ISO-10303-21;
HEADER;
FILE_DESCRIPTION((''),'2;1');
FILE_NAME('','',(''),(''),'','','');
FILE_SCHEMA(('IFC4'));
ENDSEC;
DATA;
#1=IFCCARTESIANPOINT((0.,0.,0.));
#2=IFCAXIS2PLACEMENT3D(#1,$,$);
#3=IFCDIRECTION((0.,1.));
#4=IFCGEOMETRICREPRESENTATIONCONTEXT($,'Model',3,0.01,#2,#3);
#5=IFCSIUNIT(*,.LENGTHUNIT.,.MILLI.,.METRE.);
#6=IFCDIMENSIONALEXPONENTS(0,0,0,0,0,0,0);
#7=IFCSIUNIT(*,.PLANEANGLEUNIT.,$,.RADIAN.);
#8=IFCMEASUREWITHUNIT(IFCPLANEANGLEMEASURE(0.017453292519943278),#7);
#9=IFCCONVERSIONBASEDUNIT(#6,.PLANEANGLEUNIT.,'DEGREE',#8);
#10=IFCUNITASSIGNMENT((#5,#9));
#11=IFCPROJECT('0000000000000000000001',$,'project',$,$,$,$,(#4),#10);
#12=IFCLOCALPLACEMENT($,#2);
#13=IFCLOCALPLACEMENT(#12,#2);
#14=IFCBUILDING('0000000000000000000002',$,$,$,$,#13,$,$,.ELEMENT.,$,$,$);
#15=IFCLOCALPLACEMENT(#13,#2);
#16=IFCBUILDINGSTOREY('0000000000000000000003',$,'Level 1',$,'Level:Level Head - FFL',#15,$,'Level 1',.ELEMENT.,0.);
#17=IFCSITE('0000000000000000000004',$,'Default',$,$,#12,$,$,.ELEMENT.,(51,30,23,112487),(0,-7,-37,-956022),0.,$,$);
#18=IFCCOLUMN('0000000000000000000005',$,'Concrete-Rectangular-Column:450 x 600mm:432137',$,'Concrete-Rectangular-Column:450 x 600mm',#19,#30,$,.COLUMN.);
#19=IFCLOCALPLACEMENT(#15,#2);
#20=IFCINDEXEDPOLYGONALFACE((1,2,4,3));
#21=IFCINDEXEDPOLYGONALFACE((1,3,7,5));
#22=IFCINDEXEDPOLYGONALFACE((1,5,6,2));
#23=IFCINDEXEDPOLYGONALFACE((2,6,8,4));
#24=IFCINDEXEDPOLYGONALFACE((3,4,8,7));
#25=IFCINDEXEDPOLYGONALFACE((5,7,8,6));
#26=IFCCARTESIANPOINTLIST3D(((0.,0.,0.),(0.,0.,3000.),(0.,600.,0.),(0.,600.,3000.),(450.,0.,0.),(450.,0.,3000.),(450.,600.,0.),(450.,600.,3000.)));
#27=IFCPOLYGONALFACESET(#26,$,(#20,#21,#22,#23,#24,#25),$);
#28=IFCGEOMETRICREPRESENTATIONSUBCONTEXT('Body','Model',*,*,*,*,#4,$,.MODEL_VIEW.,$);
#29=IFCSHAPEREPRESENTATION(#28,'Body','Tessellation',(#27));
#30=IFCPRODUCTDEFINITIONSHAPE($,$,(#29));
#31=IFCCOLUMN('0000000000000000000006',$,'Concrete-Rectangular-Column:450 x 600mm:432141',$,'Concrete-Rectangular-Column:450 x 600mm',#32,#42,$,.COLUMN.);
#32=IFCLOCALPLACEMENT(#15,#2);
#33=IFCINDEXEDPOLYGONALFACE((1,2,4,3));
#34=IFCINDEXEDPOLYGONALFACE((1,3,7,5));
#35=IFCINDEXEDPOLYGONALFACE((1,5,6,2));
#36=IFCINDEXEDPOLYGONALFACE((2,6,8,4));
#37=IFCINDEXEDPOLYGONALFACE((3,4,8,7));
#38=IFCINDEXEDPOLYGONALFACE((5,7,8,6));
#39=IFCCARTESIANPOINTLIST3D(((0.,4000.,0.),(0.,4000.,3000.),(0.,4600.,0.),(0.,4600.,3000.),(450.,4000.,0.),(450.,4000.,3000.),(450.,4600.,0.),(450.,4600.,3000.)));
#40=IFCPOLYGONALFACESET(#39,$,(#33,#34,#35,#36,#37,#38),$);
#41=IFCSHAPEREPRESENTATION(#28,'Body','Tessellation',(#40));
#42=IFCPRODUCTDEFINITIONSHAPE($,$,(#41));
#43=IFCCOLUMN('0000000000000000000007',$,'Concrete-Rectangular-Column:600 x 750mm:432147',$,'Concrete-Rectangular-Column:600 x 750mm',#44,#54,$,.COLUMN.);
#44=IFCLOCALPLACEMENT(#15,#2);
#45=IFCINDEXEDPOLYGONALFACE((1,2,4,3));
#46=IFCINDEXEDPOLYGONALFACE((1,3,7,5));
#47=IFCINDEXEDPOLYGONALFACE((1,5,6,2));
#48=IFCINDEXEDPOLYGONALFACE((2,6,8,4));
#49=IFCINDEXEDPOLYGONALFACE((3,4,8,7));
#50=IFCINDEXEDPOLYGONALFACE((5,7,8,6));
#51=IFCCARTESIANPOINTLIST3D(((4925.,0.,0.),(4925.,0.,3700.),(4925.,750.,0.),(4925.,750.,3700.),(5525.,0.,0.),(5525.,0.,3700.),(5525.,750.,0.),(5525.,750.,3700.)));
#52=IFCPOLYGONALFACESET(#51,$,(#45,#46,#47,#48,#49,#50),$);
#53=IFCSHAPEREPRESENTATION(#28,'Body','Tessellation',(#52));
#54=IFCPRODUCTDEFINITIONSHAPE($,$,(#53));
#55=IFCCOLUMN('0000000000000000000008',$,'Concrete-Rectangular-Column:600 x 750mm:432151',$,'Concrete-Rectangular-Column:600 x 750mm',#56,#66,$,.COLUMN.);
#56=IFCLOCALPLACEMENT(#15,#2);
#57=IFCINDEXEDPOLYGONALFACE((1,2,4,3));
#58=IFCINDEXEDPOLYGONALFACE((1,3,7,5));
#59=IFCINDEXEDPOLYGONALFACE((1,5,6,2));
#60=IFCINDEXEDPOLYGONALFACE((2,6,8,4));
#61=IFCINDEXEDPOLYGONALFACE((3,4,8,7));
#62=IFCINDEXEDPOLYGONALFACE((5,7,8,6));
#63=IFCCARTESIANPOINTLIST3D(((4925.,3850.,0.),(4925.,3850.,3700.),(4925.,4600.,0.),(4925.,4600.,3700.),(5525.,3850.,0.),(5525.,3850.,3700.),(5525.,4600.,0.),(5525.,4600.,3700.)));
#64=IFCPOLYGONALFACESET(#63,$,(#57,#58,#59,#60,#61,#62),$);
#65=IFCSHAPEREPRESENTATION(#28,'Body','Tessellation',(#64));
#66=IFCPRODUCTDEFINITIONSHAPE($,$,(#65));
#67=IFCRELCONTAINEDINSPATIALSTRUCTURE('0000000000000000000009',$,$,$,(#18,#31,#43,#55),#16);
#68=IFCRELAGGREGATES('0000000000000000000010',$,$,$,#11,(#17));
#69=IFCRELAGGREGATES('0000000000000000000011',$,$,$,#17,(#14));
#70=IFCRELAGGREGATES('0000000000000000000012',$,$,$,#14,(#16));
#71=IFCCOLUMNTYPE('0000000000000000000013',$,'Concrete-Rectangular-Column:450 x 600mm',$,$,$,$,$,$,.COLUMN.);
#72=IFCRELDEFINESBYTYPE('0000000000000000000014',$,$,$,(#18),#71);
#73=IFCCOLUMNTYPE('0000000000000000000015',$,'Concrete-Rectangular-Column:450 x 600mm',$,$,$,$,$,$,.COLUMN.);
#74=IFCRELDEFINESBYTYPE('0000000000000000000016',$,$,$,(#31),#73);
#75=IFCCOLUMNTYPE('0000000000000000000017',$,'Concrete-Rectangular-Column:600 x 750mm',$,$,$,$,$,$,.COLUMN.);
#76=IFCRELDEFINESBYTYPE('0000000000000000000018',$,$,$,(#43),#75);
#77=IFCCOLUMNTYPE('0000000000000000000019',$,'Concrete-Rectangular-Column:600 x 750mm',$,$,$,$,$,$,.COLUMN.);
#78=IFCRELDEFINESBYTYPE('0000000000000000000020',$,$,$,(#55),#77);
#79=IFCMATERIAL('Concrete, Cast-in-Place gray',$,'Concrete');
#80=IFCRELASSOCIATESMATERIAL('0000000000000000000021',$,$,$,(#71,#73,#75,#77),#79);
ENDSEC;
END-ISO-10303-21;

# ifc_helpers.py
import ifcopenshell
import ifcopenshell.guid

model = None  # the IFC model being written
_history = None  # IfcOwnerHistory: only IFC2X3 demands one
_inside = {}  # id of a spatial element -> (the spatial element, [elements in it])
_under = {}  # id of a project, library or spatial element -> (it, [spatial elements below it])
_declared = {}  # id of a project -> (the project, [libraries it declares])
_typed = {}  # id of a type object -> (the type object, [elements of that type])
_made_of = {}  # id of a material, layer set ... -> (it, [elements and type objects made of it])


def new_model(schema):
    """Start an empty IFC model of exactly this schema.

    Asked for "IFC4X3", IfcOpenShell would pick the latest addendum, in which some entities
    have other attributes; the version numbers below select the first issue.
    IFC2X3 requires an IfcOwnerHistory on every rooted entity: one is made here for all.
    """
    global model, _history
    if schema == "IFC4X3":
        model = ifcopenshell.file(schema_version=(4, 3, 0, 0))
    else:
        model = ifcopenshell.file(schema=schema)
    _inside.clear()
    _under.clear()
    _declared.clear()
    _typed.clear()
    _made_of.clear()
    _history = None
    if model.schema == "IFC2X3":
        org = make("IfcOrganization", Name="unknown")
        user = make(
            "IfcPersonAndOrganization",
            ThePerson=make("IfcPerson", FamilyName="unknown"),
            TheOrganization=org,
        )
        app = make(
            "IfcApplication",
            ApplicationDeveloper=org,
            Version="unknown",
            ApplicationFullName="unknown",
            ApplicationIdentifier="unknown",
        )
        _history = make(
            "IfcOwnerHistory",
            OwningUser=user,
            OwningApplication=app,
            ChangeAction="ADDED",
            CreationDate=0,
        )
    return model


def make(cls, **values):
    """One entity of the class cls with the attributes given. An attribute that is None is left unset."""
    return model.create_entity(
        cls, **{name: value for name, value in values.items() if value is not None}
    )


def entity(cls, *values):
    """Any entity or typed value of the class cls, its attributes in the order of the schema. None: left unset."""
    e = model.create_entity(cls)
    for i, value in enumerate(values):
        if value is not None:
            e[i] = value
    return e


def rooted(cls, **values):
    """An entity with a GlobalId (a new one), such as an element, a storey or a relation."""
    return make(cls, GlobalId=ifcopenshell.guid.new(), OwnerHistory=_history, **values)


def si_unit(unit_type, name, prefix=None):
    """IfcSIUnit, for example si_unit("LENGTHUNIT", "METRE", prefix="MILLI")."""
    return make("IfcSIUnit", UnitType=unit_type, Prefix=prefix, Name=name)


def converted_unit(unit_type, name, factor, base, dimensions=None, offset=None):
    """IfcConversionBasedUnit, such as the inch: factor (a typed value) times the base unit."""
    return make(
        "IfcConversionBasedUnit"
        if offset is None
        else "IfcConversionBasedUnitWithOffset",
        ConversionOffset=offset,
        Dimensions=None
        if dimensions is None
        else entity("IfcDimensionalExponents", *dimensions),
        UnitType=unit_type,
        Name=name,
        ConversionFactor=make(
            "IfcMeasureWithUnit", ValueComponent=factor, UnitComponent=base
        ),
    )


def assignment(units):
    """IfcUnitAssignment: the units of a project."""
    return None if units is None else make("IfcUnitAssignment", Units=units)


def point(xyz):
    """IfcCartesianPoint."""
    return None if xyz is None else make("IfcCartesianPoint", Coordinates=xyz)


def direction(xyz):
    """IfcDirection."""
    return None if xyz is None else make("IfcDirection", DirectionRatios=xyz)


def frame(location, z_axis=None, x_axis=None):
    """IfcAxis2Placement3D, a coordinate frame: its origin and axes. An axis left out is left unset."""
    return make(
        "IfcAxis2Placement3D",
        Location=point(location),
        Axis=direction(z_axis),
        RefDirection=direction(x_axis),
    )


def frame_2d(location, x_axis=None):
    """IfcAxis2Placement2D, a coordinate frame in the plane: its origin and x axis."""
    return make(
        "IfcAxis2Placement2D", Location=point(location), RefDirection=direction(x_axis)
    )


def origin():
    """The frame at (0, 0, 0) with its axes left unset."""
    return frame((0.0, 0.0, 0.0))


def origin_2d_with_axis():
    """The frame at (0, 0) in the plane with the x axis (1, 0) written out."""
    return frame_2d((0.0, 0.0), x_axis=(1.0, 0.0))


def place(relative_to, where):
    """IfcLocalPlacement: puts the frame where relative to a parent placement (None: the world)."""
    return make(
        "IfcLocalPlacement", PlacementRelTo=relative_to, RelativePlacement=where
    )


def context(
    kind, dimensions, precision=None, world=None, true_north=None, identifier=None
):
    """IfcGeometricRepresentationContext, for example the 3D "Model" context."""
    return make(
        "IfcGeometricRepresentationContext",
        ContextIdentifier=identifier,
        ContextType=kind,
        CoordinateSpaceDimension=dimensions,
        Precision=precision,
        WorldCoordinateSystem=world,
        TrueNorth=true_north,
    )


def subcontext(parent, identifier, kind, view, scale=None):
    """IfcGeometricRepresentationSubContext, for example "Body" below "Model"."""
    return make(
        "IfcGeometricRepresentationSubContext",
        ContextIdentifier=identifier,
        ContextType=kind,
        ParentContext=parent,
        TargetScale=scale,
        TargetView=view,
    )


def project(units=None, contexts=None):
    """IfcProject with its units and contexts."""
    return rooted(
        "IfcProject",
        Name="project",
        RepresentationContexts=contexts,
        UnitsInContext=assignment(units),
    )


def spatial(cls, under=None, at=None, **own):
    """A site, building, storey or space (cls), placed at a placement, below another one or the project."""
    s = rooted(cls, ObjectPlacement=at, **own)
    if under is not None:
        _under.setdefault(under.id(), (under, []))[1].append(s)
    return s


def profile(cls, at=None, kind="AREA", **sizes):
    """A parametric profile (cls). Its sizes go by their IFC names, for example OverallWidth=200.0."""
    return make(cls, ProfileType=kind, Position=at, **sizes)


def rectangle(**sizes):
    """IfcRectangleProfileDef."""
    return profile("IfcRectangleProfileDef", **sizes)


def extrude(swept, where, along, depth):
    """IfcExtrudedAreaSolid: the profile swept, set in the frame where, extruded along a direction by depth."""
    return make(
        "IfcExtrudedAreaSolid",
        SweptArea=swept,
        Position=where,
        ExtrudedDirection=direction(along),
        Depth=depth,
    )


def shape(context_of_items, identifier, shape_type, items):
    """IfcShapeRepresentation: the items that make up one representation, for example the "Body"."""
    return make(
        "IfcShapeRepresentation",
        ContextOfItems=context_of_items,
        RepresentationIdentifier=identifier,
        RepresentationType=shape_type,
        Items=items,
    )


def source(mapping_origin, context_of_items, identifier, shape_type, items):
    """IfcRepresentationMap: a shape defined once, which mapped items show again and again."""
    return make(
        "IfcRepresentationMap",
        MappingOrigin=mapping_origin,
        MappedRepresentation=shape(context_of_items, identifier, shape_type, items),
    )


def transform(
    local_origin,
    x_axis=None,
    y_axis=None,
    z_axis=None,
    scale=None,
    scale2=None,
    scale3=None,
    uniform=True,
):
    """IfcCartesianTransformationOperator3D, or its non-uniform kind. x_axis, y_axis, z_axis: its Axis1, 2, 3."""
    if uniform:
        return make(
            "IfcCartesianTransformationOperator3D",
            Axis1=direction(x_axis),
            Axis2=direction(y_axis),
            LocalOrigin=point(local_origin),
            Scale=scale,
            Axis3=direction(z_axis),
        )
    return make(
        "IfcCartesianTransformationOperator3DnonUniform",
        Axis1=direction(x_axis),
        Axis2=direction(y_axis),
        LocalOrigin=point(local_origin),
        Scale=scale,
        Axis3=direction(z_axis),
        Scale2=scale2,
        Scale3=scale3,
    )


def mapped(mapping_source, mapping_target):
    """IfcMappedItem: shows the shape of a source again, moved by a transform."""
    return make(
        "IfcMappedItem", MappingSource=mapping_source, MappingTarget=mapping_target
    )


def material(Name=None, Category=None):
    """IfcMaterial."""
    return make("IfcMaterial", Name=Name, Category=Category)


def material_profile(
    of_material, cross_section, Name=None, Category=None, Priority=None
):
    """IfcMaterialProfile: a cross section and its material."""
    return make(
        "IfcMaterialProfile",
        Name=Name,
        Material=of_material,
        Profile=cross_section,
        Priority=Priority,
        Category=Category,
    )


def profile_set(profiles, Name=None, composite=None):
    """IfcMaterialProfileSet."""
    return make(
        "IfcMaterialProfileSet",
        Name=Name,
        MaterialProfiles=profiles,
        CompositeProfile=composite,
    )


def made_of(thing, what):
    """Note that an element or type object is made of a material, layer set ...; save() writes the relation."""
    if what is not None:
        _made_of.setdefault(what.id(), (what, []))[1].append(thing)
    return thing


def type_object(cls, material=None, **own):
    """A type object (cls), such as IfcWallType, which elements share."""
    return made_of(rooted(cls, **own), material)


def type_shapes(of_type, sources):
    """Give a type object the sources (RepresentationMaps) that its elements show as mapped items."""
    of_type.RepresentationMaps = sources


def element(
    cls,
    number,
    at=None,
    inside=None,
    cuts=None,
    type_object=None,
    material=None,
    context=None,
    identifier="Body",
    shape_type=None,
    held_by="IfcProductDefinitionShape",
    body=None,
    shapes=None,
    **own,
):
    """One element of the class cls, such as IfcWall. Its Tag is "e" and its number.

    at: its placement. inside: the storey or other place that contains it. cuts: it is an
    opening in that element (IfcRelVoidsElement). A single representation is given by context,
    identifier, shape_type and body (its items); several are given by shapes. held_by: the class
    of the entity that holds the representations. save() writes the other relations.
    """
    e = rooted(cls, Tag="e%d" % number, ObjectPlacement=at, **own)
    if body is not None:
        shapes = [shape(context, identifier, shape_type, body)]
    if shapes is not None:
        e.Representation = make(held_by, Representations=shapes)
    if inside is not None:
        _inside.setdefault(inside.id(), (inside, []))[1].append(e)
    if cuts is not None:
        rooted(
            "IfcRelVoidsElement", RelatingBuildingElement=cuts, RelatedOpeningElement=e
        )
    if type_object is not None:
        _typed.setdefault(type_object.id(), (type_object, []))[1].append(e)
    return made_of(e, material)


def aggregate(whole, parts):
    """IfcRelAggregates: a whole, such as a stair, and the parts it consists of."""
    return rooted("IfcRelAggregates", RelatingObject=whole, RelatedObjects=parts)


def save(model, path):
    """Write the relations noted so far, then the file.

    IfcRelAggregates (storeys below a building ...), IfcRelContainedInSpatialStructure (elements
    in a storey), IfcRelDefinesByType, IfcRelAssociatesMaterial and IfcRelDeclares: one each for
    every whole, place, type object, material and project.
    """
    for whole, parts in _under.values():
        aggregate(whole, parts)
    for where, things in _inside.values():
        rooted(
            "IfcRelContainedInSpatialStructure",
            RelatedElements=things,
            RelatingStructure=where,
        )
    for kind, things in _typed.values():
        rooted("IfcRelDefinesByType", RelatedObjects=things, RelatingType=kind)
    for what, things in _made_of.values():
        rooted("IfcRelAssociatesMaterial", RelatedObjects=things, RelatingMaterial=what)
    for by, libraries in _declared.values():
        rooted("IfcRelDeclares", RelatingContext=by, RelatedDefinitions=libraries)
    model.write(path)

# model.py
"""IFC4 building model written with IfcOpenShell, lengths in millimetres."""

from ifc_helpers import new_model, entity, si_unit, converted_unit, direction, frame, frame_2d, origin, origin_2d_with_axis, place, context, subcontext, project, spatial, rectangle, extrude, source, transform, mapped, material, material_profile, profile_set, type_object, type_shapes, element, save


model = new_model("IFC4")

# Units and contexts
model_context = context("Model", 3, precision=0.01, world=origin(), true_north=direction((0.0, 1.0)))
body_context = subcontext(model_context, "Body", "Model", "MODEL_VIEW")
ifc_project = project(units=[si_unit("LENGTHUNIT", "METRE", prefix="MILLI"), converted_unit("PLANEANGLEUNIT", "DEGREE", entity("IfcPlaneAngleMeasure", 0.017453292519943278), si_unit("PLANEANGLEUNIT", "RADIAN"), dimensions=[0, 0, 0, 0, 0, 0, 0])], contexts=[model_context])

# Site, building, storey
site_placement = place(None, origin())
site = spatial("IfcSite", under=ifc_project, at=site_placement, Name="Default", CompositionType="ELEMENT", RefLatitude=(51, 30, 23, 112487), RefLongitude=(0, -7, -37, -956022), RefElevation=0.0)
building_placement = place(site_placement, origin())
building = spatial("IfcBuilding", under=site, at=building_placement, CompositionType="ELEMENT")
storey_placement = place(building_placement, origin())
storey = spatial("IfcBuildingStorey", under=building, at=storey_placement, Name="Level 1", ObjectType="Level:Level Head - FFL", LongName="Level 1", CompositionType="ELEMENT", Elevation=0.0)

# Columns
ifc_material = material(Name="Concrete, Cast-in-Place gray", Category="Concrete")
ifc_material_profile_1 = material_profile(ifc_material, rectangle(XDim=450.0, YDim=600.0, at=frame_2d((0.0, 0.0), x_axis=(1.0, 0.0))), Name="450 x 600mm")
ifc_profile_set_1 = profile_set([ifc_material_profile_1], Name="450 x 600mm")
column_type_1 = type_object("IfcColumnType", Name="Concrete-Rectangular-Column:450 x 600mm", PredefinedType="COLUMN", material=ifc_profile_set_1)
shared_shape_1 = source(origin(), body_context, "Body", "SweptSolid", [
    extrude(rectangle(XDim=450.0, YDim=600.0, at=frame_2d((0.0, 0.0), x_axis=(1.0, 0.0))), frame((225.0, 300.0, 0.0), z_axis=(0.0, 0.0, 1.0), x_axis=(-1.0, 0.0, 0.0)), (0.0, 0.0, 1.0), 3000.0),
])
type_shapes(column_type_1, [shared_shape_1])
column_1_placement = place(storey_placement, origin())
element("IfcColumn", 1, at=column_1_placement, inside=storey, type_object=column_type_1, Name="Concrete-Rectangular-Column:450 x 600mm:432137", ObjectType="Concrete-Rectangular-Column:450 x 600mm", PredefinedType="COLUMN", context=body_context, shape_type="MappedRepresentation", body=[
    mapped(shared_shape_1, transform((0.0, 0.0, 0.0), scale=1.0)),
])
column_type_2 = type_object("IfcColumnType", Name="Concrete-Rectangular-Column:450 x 600mm", PredefinedType="COLUMN", material=ifc_profile_set_1)
shared_shape_2 = source(origin(), body_context, "Body", "SweptSolid", [
    extrude(rectangle(XDim=450.0, YDim=600.0, at=origin_2d_with_axis()), frame((225.0, 4300.0, 0.0), z_axis=(0.0, 0.0, 1.0), x_axis=(-1.0, 0.0, 0.0)), (0.0, 0.0, 1.0), 3000.0),
])
type_shapes(column_type_2, [shared_shape_2])
column_2_placement = place(storey_placement, origin())
element("IfcColumn", 2, at=column_2_placement, inside=storey, type_object=column_type_2, Name="Concrete-Rectangular-Column:450 x 600mm:432141", ObjectType="Concrete-Rectangular-Column:450 x 600mm", PredefinedType="COLUMN", context=body_context, shape_type="MappedRepresentation", body=[
    mapped(shared_shape_2, transform((0.0, 0.0, 0.0), scale=1.0)),
])
ifc_material_profile_2 = material_profile(ifc_material, rectangle(XDim=600.0, YDim=750.0, at=frame_2d((0.0, 0.0), x_axis=(1.0, 0.0))), Name="600 x 750mm")
ifc_profile_set_2 = profile_set([ifc_material_profile_2], Name="600 x 750mm")
column_type_3 = type_object("IfcColumnType", Name="Concrete-Rectangular-Column:600 x 750mm", PredefinedType="COLUMN", material=ifc_profile_set_2)
shared_shape_3 = source(origin(), body_context, "Body", "SweptSolid", [
    extrude(rectangle(XDim=600.0, YDim=750.0, at=frame_2d((0.0, 0.0), x_axis=(1.0, 0.0))), frame((5225.0, 375.0, 0.0), z_axis=(0.0, 0.0, 1.0), x_axis=(-1.0, 0.0, 0.0)), (0.0, 0.0, 1.0), 3700.0),
])
type_shapes(column_type_3, [shared_shape_3])
column_3_placement = place(storey_placement, origin())
element("IfcColumn", 3, at=column_3_placement, inside=storey, type_object=column_type_3, Name="Concrete-Rectangular-Column:600 x 750mm:432147", ObjectType="Concrete-Rectangular-Column:600 x 750mm", PredefinedType="COLUMN", context=body_context, shape_type="MappedRepresentation", body=[
    mapped(shared_shape_3, transform((0.0, 0.0, 0.0), scale=1.0)),
])
column_type_4 = type_object("IfcColumnType", Name="Concrete-Rectangular-Column:600 x 750mm", PredefinedType="COLUMN", material=ifc_profile_set_2)
shared_shape_4 = source(origin(), body_context, "Body", "SweptSolid", [
    extrude(rectangle(XDim=600.0, YDim=750.0, at=frame_2d((0.0, 0.0), x_axis=(1.0, 0.0))), frame((5225.0, 4225.0, 0.0), z_axis=(0.0, 0.0, 1.0), x_axis=(-1.0, 0.0, 0.0)), (0.0, 0.0, 1.0), 3700.0),
])
type_shapes(column_type_4, [shared_shape_4])
column_4_placement = place(storey_placement, origin())
element("IfcColumn", 4, at=column_4_placement, inside=storey, type_object=column_type_4, Name="Concrete-Rectangular-Column:600 x 750mm:432151", ObjectType="Concrete-Rectangular-Column:600 x 750mm", PredefinedType="COLUMN", context=body_context, shape_type="MappedRepresentation", body=[
    mapped(shared_shape_4, transform((0.0, 0.0, 0.0), scale=1.0)),
])

save(model, "model.ifc")
